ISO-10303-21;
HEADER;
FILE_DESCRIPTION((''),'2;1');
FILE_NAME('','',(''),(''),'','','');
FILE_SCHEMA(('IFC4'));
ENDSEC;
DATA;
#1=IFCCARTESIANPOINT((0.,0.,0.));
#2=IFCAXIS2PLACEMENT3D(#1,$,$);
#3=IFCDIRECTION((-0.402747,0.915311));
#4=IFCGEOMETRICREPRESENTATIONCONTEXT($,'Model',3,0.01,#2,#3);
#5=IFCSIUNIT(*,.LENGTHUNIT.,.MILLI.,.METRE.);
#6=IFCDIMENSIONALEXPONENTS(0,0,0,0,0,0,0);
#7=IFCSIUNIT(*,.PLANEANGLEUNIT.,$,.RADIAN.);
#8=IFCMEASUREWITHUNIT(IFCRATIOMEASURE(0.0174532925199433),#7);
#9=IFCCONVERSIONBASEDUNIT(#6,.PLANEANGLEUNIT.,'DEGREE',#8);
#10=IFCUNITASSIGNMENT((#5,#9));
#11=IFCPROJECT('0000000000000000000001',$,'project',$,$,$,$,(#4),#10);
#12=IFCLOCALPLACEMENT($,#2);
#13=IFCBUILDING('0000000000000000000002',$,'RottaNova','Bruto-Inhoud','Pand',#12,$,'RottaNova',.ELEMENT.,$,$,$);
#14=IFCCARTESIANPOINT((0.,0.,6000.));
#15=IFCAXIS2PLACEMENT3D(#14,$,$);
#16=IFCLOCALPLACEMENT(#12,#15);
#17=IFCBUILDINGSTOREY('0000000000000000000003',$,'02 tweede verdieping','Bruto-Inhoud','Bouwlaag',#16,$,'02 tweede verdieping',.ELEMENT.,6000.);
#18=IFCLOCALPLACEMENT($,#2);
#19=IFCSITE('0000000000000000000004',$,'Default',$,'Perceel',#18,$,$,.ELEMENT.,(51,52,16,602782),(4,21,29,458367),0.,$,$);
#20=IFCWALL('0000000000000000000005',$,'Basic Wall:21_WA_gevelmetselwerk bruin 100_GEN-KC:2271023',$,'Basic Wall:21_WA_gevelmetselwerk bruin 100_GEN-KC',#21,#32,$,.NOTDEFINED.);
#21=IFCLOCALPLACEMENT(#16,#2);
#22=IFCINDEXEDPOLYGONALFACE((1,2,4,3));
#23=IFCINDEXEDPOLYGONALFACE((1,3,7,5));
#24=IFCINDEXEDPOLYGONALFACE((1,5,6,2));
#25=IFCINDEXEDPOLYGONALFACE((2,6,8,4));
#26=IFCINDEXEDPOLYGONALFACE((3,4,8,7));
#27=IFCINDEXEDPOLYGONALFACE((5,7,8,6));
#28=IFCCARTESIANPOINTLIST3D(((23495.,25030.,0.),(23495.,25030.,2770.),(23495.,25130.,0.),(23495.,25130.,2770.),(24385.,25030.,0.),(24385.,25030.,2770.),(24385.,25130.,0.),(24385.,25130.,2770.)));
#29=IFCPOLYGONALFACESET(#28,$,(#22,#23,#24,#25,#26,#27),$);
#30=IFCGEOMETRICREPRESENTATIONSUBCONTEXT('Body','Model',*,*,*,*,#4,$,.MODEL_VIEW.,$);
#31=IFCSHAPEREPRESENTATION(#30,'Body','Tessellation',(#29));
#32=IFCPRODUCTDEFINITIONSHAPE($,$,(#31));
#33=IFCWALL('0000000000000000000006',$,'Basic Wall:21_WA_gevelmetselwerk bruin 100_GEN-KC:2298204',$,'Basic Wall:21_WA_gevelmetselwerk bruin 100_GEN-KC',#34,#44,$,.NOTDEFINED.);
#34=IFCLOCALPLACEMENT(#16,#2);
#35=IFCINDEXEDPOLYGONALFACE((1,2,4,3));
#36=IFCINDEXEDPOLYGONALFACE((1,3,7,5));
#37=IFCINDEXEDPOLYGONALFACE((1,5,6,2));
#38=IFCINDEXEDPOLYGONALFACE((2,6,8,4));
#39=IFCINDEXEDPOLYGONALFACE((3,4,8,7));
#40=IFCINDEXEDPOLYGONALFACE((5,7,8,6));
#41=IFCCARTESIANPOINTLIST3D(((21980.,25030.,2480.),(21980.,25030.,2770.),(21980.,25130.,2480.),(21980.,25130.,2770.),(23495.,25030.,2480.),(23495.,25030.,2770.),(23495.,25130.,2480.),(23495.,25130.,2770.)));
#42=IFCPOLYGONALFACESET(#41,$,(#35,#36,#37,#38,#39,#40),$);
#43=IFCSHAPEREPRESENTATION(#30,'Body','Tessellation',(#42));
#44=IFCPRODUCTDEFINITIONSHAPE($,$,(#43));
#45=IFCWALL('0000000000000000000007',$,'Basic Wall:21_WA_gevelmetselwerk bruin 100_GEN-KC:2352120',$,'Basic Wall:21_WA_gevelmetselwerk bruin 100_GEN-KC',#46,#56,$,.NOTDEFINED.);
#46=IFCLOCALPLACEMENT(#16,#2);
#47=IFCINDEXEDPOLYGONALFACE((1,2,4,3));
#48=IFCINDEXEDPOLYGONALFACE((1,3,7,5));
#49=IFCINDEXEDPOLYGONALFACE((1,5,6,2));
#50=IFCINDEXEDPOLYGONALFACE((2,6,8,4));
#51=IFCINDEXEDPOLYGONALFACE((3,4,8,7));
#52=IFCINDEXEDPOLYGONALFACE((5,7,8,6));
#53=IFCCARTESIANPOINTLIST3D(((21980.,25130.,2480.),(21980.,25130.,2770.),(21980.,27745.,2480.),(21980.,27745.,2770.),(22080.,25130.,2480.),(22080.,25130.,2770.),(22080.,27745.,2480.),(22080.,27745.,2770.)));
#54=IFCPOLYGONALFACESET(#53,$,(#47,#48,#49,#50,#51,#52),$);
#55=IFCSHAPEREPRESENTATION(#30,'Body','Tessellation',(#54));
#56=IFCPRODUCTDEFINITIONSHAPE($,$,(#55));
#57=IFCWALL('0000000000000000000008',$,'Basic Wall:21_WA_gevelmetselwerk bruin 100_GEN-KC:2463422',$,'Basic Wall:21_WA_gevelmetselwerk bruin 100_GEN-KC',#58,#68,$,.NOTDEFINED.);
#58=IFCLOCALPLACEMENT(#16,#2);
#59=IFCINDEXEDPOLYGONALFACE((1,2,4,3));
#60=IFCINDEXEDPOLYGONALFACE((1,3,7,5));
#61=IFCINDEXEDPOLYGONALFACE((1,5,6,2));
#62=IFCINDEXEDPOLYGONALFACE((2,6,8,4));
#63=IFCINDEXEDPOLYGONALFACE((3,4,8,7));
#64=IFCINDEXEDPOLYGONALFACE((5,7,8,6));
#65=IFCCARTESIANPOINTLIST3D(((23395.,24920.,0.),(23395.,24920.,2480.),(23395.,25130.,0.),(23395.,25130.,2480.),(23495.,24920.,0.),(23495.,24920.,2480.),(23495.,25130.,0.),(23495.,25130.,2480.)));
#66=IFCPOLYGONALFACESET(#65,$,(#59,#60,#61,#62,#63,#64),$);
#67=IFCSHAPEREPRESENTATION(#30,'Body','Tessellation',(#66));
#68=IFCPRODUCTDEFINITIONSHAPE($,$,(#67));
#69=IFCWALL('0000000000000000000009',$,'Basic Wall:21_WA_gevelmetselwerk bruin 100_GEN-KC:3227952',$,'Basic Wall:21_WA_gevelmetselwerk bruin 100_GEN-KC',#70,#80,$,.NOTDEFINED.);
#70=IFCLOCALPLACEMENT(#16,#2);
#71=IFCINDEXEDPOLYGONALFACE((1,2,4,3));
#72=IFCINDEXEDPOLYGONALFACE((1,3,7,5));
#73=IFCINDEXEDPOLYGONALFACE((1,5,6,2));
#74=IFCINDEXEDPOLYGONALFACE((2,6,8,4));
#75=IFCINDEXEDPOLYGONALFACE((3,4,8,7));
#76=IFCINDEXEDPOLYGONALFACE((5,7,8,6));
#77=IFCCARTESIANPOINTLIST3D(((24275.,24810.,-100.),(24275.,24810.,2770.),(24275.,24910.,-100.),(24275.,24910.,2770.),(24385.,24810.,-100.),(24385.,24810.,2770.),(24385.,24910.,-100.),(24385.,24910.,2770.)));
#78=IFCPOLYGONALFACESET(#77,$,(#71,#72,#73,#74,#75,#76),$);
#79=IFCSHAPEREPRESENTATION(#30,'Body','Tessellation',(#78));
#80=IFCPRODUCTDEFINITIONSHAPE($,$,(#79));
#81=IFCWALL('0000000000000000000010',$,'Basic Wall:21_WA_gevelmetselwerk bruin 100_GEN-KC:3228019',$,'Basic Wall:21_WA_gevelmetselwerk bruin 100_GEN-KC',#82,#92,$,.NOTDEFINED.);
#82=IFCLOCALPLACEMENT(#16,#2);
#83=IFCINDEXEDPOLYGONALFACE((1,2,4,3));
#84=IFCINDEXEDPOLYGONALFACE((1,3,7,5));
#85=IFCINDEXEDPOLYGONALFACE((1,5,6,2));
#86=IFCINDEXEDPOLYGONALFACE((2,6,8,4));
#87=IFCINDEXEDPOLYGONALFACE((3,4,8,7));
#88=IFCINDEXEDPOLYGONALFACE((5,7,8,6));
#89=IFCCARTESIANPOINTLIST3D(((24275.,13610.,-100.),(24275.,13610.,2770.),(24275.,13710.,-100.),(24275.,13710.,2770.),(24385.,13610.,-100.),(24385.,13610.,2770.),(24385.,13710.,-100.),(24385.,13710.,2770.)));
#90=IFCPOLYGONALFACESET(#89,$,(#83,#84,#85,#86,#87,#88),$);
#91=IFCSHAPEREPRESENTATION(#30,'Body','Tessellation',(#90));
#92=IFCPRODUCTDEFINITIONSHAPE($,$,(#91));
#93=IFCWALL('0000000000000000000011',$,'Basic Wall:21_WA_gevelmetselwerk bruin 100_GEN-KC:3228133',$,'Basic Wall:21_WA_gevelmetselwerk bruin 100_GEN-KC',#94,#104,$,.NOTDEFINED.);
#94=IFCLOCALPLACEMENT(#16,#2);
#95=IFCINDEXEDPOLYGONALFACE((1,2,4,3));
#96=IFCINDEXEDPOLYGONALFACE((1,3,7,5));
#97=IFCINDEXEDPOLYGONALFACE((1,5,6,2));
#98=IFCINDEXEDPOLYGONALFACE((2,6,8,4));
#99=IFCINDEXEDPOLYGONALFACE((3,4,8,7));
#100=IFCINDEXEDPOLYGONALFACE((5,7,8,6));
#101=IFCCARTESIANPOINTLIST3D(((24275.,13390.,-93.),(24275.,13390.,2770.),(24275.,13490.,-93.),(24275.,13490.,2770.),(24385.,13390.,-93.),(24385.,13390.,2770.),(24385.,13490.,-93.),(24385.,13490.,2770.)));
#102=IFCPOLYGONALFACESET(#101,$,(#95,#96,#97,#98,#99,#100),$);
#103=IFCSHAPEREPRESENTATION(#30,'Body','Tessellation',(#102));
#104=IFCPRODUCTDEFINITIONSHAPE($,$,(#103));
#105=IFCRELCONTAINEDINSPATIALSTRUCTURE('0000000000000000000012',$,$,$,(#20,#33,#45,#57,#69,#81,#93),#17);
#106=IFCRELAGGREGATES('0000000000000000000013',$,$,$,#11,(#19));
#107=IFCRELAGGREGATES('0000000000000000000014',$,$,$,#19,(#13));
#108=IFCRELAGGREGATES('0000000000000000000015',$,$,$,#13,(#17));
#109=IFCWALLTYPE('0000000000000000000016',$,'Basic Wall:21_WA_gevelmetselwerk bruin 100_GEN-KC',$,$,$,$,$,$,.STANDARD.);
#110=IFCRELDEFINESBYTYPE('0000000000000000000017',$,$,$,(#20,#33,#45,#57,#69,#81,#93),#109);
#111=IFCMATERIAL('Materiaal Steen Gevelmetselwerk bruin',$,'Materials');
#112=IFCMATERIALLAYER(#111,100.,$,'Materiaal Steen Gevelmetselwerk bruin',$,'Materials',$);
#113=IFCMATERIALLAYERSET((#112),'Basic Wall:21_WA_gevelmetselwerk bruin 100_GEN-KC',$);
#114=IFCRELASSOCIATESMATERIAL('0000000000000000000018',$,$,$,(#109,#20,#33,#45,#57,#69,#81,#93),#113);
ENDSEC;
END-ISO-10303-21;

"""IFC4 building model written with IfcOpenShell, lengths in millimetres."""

from ifc_helpers import new_model, entity, si_unit, converted_unit, direction, frame, frame_2d, origin, place, context, subcontext, project, spatial, rectangle, extrude, material, layer, layer_set, type_object, element, save


model = new_model("IFC4")

# Units and contexts
model_context = context("Model", 3, precision=0.01, world=origin(), true_north=direction((-0.402747, 0.915311)))
body_context = subcontext(model_context, "Body", "Model", "MODEL_VIEW")
ifc_project = project(units=[si_unit("LENGTHUNIT", "METRE", prefix="MILLI"), converted_unit("PLANEANGLEUNIT", "DEGREE", entity("IfcRatioMeasure", 0.0174532925199433), si_unit("PLANEANGLEUNIT", "RADIAN"), dimensions=[0, 0, 0, 0, 0, 0, 0])], contexts=[model_context])

# Site, building, storey
site_placement = place(None, origin())
site = spatial("IfcSite", under=ifc_project, at=site_placement, Name="Default", ObjectType="Perceel", CompositionType="ELEMENT", RefLatitude=(51, 52, 16, 602782), RefLongitude=(4, 21, 29, 458367), RefElevation=0.0)
building_placement = place(None, origin())
building = spatial("IfcBuilding", under=site, at=building_placement, Name="RottaNova", Description="Bruto-Inhoud", ObjectType="Pand", LongName="RottaNova", CompositionType="ELEMENT")
storey_placement = place(building_placement, frame((0.0, 0.0, 6000.0)))
storey = spatial("IfcBuildingStorey", under=building, at=storey_placement, Name="02 tweede verdieping", Description="Bruto-Inhoud", ObjectType="Bouwlaag", LongName="02 tweede verdieping", CompositionType="ELEMENT", Elevation=6000.0)

# Walls
ifc_material_1 = material(Name="Materiaal Steen Gevelmetselwerk bruin", Category="Materials")
ifc_layer_1 = layer(ifc_material_1, 100.0, Name="Materiaal Steen Gevelmetselwerk bruin", Category="Materials")
ifc_layer_set_1 = layer_set([ifc_layer_1], Name="Basic Wall:21_WA_gevelmetselwerk bruin 100_GEN-KC")
wall_type_1 = type_object("IfcWallType", Name="Basic Wall:21_WA_gevelmetselwerk bruin 100_GEN-KC", PredefinedType="STANDARD", material=ifc_layer_set_1)
wall_1_placement = place(storey_placement, frame((24385.0, 25080.0, 0.0), z_axis=(0.0, 0.0, 1.0), x_axis=(-1.0, 0.0, 0.0)))
element("IfcWall", 1, at=wall_1_placement, inside=storey, type_object=wall_type_1, material=ifc_layer_set_1, Name="Basic Wall:21_WA_gevelmetselwerk bruin 100_GEN-KC:2271023", ObjectType="Basic Wall:21_WA_gevelmetselwerk bruin 100_GEN-KC", PredefinedType="NOTDEFINED", context=body_context, shape_type="SweptSolid", body=[
    extrude(rectangle(XDim=890.0, YDim=100.0, at=frame_2d((445.0, 0.0), x_axis=(-1.0, 0.0))), origin(), (0.0, 0.0, 1.0), 2770.0),
])
wall_2_placement = place(storey_placement, frame((23495.0, 25080.0, 2480.0), z_axis=(0.0, 0.0, 1.0), x_axis=(-1.0, 0.0, 0.0)))
element("IfcWall", 2, at=wall_2_placement, inside=storey, type_object=wall_type_1, material=ifc_layer_set_1, Name="Basic Wall:21_WA_gevelmetselwerk bruin 100_GEN-KC:2298204", ObjectType="Basic Wall:21_WA_gevelmetselwerk bruin 100_GEN-KC", PredefinedType="NOTDEFINED", context=body_context, shape_type="SweptSolid", body=[
    extrude(rectangle(XDim=1515.0, YDim=100.0, at=frame_2d((757.5, 0.0), x_axis=(-1.0, 0.0))), origin(), (0.0, 0.0, 1.0), 290.0),
])
wall_3_placement = place(storey_placement, frame((22030.0, 25130.0, 2480.0), z_axis=(0.0, 0.0, 1.0), x_axis=(0.0, 1.0, 0.0)))
element("IfcWall", 3, at=wall_3_placement, inside=storey, type_object=wall_type_1, material=ifc_layer_set_1, Name="Basic Wall:21_WA_gevelmetselwerk bruin 100_GEN-KC:2352120", ObjectType="Basic Wall:21_WA_gevelmetselwerk bruin 100_GEN-KC", PredefinedType="NOTDEFINED", context=body_context, shape_type="SweptSolid", body=[
    extrude(rectangle(XDim=2615.0, YDim=100.0, at=frame_2d((1307.5, 0.0), x_axis=(-1.0, 0.0))), origin(), (0.0, 0.0, 1.0), 290.0),
])
wall_4_placement = place(storey_placement, frame((23445.0, 24920.0, 0.0), z_axis=(0.0, 0.0, 1.0), x_axis=(0.0, 1.0, 0.0)))
element("IfcWall", 4, at=wall_4_placement, inside=storey, type_object=wall_type_1, material=ifc_layer_set_1, Name="Basic Wall:21_WA_gevelmetselwerk bruin 100_GEN-KC:2463422", ObjectType="Basic Wall:21_WA_gevelmetselwerk bruin 100_GEN-KC", PredefinedType="NOTDEFINED", context=body_context, shape_type="SweptSolid", body=[
    extrude(rectangle(XDim=210.0, YDim=100.0, at=frame_2d((105.0, 0.0), x_axis=(-1.0, 0.0))), origin(), (0.0, 0.0, 1.0), 2480.0),
])
wall_5_placement = place(storey_placement, frame((24385.0, 24860.0, -100.0), z_axis=(0.0, 0.0, 1.0), x_axis=(-1.0, 0.0, 0.0)))
element("IfcWall", 5, at=wall_5_placement, inside=storey, type_object=wall_type_1, material=ifc_layer_set_1, Name="Basic Wall:21_WA_gevelmetselwerk bruin 100_GEN-KC:3227952", ObjectType="Basic Wall:21_WA_gevelmetselwerk bruin 100_GEN-KC", PredefinedType="NOTDEFINED", context=body_context, shape_type="SweptSolid", body=[
    extrude(rectangle(XDim=110.0, YDim=100.0, at=frame_2d((55.0, 0.0), x_axis=(-1.0, 0.0))), origin(), (0.0, 0.0, 1.0), 2870.0),
])
wall_6_placement = place(storey_placement, frame((24385.0, 13660.0, -100.0), z_axis=(0.0, 0.0, 1.0), x_axis=(-1.0, 0.0, 0.0)))
element("IfcWall", 6, at=wall_6_placement, inside=storey, type_object=wall_type_1, material=ifc_layer_set_1, Name="Basic Wall:21_WA_gevelmetselwerk bruin 100_GEN-KC:3228019", ObjectType="Basic Wall:21_WA_gevelmetselwerk bruin 100_GEN-KC", PredefinedType="NOTDEFINED", context=body_context, shape_type="SweptSolid", body=[
    extrude(rectangle(XDim=110.0, YDim=100.0, at=frame_2d((55.0, 0.0), x_axis=(-1.0, 0.0))), origin(), (0.0, 0.0, 1.0), 2870.0),
])
wall_7_placement = place(storey_placement, frame((24385.0, 13440.0, -93.0), z_axis=(0.0, 0.0, 1.0), x_axis=(-1.0, 0.0, 0.0)))
element("IfcWall", 7, at=wall_7_placement, inside=storey, type_object=wall_type_1, material=ifc_layer_set_1, Name="Basic Wall:21_WA_gevelmetselwerk bruin 100_GEN-KC:3228133", ObjectType="Basic Wall:21_WA_gevelmetselwerk bruin 100_GEN-KC", PredefinedType="NOTDEFINED", context=body_context, shape_type="SweptSolid", body=[
    extrude(rectangle(XDim=110.0, YDim=100.0, at=frame_2d((55.0, 0.0), x_axis=(-1.0, 0.0))), origin(), (0.0, 0.0, 1.0), 2863.0),
])

save(model, "model.ifc")
